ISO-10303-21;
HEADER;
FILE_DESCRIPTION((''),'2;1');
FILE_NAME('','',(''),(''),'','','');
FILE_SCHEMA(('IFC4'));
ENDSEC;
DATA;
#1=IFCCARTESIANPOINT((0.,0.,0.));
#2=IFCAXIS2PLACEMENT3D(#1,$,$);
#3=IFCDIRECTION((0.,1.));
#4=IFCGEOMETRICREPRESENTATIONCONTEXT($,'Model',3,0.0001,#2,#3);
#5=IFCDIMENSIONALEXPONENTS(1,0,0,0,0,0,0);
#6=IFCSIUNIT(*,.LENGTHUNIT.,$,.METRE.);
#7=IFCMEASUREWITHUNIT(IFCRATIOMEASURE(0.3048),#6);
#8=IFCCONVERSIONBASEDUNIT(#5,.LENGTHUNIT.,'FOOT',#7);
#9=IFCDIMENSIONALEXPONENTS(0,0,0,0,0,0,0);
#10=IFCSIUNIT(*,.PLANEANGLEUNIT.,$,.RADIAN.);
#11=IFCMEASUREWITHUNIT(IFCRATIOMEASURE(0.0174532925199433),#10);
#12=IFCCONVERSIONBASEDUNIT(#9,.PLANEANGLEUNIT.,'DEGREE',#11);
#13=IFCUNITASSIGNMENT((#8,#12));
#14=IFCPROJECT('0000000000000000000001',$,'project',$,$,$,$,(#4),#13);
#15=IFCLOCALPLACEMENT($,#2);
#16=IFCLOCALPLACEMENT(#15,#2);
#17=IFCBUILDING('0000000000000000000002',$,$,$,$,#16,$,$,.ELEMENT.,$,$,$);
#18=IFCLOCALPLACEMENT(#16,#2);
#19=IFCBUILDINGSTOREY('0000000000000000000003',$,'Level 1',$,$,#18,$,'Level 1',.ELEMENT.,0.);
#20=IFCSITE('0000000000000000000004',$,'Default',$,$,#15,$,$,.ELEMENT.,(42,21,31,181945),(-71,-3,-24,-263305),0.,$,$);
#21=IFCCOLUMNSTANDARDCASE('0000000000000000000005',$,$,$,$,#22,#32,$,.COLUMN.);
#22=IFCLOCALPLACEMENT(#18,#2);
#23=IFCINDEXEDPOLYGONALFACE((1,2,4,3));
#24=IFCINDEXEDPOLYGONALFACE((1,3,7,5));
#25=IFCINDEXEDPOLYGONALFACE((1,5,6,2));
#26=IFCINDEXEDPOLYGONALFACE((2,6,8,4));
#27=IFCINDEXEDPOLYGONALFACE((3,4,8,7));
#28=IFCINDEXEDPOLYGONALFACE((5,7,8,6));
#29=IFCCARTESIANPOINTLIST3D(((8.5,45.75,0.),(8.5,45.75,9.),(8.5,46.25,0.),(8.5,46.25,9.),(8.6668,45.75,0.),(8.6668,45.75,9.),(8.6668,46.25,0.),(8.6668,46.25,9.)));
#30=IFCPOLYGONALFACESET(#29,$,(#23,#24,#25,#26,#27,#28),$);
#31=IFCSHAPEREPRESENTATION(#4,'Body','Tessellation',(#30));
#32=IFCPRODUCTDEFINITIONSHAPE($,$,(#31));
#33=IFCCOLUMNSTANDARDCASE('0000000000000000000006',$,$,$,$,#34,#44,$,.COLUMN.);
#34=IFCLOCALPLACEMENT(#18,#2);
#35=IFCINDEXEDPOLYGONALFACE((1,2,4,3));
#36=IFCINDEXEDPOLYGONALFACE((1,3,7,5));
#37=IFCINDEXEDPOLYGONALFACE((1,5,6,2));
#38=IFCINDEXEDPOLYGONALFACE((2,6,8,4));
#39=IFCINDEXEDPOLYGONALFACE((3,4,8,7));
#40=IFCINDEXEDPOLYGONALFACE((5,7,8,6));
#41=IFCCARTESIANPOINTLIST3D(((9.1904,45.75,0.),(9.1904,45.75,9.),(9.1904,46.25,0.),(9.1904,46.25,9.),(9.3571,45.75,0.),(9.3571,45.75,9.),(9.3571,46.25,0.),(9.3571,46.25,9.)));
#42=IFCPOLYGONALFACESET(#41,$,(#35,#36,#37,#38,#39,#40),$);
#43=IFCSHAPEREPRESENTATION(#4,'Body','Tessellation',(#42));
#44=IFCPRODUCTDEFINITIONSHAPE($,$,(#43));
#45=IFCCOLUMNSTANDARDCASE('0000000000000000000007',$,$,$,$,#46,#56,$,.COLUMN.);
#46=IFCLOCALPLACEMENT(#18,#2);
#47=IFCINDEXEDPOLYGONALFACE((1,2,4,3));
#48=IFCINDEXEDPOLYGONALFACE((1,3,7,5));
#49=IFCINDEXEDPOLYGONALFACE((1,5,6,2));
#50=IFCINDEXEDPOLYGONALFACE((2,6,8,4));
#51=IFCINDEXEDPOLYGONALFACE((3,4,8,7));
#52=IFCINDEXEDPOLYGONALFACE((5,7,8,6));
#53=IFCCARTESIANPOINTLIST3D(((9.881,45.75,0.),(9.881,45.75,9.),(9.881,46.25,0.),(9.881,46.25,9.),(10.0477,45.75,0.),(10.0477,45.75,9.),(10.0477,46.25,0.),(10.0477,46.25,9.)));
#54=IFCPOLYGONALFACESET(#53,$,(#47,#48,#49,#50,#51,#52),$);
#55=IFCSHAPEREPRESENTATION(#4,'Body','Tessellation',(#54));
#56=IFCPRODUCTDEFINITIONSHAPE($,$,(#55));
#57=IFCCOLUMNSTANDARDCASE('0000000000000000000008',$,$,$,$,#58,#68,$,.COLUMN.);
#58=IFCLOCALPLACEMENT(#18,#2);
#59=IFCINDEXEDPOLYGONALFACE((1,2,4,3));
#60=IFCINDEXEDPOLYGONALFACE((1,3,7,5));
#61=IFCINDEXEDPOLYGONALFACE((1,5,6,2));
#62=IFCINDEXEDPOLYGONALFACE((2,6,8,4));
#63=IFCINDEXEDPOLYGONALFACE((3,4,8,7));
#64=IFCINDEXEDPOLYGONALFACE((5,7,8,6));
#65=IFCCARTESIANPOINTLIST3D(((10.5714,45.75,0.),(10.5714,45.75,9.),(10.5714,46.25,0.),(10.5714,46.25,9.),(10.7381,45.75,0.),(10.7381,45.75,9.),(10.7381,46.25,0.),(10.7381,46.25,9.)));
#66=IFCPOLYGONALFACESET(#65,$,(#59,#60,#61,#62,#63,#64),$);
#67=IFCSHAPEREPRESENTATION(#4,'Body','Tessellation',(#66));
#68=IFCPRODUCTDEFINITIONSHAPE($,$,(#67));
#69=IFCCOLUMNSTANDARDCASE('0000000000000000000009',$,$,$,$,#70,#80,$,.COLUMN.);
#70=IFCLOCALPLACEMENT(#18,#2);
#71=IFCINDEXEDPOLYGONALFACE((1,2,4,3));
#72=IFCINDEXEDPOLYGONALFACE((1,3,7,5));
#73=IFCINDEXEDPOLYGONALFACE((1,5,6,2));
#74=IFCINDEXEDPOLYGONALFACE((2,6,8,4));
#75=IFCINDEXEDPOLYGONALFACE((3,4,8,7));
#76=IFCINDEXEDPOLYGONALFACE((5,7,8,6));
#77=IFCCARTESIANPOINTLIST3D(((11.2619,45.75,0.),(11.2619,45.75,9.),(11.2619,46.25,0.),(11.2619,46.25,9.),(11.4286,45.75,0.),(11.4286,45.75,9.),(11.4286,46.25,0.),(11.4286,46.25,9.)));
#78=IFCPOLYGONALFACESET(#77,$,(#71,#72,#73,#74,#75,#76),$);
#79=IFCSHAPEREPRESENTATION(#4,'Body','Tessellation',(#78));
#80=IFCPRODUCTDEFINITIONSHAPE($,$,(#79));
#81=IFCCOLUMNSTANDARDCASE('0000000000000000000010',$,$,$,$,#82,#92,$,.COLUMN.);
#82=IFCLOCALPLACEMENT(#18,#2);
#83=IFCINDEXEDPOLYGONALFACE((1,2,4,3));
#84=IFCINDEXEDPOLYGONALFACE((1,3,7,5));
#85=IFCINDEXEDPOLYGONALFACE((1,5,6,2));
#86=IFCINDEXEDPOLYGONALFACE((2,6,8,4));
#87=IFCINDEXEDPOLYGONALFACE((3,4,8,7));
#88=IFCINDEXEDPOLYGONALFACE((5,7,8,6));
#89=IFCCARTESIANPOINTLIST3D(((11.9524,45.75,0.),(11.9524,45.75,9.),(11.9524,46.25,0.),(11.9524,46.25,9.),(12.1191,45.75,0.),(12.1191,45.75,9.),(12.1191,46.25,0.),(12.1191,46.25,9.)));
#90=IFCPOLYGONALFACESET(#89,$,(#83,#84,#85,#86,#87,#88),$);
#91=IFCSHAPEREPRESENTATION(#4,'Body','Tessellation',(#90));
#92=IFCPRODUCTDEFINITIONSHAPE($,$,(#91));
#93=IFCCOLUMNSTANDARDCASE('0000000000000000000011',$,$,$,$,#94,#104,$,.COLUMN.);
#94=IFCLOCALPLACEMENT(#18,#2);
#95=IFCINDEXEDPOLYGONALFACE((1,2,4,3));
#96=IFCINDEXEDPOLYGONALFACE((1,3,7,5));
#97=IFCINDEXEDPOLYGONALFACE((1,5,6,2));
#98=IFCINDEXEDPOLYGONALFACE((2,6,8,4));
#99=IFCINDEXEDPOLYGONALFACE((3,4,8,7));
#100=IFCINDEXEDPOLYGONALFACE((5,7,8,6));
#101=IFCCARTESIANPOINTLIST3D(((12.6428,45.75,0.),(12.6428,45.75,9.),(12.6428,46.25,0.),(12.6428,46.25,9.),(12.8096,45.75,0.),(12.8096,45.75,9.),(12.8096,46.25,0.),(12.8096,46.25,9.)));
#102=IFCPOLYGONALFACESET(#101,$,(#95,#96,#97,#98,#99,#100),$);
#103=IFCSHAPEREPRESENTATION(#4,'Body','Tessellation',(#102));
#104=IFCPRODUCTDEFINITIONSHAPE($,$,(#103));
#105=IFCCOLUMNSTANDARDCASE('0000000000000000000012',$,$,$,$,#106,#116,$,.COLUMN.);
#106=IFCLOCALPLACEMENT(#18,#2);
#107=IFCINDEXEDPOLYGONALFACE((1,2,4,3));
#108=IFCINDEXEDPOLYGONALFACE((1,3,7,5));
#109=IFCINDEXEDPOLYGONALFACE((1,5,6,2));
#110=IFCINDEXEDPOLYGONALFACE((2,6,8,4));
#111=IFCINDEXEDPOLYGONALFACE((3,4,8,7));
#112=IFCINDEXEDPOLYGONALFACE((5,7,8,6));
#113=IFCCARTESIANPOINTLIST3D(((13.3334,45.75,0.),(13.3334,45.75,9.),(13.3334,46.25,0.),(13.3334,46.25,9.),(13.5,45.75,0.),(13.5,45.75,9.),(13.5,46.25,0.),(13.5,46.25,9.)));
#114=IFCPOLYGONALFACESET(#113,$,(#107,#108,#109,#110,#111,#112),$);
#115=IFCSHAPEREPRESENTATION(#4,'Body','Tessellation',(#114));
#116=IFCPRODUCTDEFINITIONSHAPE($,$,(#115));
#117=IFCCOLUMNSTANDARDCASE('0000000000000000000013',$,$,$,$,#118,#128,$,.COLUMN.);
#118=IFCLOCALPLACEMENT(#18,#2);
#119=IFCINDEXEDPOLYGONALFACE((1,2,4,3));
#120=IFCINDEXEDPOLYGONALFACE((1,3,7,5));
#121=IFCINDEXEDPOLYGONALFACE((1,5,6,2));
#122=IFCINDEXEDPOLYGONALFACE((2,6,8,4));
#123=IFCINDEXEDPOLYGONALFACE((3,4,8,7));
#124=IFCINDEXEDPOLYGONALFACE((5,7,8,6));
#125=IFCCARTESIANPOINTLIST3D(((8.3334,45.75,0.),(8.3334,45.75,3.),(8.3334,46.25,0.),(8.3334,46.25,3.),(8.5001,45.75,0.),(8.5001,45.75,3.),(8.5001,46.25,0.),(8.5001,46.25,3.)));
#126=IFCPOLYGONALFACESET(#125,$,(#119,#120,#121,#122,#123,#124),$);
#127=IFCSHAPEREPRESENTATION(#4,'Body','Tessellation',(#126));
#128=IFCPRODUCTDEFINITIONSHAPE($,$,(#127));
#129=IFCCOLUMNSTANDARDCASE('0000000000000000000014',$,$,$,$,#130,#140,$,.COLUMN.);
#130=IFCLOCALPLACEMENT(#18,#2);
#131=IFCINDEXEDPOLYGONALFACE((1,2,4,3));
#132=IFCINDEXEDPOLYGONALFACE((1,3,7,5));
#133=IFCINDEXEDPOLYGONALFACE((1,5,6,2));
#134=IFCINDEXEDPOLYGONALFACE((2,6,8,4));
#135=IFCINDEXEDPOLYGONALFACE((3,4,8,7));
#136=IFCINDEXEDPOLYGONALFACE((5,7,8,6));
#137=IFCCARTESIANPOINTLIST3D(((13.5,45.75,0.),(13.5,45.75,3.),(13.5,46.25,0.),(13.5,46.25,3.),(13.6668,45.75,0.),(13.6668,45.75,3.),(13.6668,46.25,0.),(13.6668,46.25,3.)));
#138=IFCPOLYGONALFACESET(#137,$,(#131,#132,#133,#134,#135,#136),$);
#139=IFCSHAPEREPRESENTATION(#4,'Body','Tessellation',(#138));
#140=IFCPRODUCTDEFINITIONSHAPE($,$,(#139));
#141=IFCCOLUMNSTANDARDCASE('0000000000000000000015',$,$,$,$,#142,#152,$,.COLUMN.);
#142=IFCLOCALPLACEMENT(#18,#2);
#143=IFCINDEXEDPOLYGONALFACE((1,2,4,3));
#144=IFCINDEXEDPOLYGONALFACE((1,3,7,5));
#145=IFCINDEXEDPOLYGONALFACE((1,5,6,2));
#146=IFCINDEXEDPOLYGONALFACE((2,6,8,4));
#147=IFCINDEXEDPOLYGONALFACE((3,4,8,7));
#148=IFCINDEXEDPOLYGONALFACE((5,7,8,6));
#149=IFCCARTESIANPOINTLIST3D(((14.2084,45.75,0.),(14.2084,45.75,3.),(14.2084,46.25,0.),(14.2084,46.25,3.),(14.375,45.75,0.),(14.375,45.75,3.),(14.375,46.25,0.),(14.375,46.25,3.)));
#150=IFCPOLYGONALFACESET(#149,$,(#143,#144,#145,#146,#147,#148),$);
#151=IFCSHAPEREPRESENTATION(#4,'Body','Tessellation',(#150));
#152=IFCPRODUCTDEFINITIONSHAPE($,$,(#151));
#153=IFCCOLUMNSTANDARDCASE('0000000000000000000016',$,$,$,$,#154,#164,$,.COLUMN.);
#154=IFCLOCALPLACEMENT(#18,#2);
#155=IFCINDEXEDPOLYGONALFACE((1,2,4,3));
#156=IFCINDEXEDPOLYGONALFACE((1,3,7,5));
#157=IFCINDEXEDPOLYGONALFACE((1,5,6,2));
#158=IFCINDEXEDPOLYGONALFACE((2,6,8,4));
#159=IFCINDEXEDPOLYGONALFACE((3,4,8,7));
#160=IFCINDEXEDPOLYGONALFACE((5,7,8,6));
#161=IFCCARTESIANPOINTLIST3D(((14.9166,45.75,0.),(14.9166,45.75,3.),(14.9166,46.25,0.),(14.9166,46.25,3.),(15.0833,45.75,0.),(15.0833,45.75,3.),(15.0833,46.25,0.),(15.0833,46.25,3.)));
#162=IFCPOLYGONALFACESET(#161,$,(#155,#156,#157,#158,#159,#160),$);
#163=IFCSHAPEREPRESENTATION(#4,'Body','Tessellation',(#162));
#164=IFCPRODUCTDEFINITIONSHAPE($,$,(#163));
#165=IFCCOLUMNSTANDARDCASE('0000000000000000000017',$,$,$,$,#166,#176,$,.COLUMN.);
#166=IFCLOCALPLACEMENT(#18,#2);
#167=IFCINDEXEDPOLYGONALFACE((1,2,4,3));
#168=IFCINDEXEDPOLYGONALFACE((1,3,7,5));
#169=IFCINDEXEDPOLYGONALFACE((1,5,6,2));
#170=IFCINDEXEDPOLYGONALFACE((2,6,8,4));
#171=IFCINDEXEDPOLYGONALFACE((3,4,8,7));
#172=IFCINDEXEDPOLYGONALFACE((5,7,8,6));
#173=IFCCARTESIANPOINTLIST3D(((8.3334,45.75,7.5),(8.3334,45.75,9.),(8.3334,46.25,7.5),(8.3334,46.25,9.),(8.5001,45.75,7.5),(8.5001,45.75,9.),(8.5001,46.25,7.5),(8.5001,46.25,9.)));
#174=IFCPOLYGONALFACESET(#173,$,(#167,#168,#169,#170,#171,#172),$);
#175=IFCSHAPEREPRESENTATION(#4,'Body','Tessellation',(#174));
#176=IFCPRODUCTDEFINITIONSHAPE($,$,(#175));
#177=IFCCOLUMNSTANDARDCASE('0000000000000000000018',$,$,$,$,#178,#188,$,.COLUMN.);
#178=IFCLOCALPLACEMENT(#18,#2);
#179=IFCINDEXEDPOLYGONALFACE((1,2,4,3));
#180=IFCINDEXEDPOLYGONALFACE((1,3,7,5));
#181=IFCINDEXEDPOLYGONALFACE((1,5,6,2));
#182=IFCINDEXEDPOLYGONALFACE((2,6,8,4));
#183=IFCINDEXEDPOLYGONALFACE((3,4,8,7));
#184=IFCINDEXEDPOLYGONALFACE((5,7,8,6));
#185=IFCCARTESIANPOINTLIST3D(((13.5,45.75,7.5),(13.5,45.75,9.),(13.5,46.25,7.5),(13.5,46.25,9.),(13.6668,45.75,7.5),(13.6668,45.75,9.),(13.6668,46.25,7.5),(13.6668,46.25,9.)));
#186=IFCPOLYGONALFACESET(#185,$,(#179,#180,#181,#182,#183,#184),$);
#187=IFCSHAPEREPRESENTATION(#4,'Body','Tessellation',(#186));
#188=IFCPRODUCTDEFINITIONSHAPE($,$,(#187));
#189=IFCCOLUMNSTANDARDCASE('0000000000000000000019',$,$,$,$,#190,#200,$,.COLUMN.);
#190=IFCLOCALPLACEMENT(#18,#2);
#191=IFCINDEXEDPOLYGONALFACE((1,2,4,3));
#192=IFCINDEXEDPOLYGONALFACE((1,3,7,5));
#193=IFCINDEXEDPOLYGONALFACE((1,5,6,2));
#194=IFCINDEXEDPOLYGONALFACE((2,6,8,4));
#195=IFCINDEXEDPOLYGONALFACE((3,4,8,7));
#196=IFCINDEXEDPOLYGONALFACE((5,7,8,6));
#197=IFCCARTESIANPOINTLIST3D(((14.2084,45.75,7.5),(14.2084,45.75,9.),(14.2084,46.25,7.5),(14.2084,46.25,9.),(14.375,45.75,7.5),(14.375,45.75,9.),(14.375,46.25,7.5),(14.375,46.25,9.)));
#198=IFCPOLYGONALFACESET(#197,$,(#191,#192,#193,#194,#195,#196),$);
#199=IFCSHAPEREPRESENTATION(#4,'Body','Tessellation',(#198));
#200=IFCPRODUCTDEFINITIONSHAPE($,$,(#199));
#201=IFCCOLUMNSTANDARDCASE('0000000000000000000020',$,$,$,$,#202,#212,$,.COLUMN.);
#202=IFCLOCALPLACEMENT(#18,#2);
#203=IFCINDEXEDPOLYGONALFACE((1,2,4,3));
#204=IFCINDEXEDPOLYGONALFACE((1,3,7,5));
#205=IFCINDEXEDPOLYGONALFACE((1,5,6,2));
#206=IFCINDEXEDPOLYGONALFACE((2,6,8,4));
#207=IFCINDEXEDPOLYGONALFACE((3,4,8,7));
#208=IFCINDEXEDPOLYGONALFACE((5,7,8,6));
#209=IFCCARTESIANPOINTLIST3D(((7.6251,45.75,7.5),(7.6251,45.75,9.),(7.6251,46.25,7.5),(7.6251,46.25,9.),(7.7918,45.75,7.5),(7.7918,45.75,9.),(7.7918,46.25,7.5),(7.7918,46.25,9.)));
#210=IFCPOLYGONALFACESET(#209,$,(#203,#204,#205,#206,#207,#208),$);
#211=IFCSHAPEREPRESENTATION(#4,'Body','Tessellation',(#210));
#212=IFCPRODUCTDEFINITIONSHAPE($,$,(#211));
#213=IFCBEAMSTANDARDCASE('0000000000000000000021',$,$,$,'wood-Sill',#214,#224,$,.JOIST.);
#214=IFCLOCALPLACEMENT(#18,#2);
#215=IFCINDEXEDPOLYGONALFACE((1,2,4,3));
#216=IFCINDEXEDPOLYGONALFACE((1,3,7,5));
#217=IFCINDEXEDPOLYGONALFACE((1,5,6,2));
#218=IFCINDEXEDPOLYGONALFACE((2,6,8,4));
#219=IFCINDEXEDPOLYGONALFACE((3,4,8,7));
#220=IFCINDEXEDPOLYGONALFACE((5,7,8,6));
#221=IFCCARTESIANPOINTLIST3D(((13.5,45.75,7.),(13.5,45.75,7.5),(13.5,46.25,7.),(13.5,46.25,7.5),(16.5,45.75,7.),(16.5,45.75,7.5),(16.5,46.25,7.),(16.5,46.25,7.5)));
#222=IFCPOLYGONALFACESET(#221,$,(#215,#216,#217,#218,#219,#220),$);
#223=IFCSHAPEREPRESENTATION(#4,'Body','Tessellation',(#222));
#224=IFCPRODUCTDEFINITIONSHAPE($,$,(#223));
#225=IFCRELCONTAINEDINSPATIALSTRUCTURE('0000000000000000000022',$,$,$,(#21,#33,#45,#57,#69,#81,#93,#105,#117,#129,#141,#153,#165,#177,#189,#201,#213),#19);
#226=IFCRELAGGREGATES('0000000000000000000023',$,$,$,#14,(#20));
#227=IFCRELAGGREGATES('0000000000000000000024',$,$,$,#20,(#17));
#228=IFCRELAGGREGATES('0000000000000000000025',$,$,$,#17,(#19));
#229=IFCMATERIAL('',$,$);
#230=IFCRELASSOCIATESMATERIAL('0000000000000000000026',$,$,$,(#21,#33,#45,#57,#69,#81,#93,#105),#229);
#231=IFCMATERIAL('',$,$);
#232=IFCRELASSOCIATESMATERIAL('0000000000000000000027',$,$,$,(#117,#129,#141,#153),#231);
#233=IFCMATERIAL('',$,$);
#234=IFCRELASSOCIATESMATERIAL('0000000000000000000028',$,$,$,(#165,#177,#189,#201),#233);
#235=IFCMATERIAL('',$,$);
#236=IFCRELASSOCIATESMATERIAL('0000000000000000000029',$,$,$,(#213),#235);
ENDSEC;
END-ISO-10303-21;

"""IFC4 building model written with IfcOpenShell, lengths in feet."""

from ifc_helpers import new_model, entity, si_unit, converted_unit, direction, frame, origin, place, context, project, spatial, rectangle, extrude, material, element, save


model = new_model("IFC4")

# Units and contexts
model_context = context("Model", 3, precision=0.0001, world=origin(), true_north=direction((0.0, 1.0)))
ifc_project = project(units=[converted_unit("LENGTHUNIT", "FOOT", entity("IfcRatioMeasure", 0.3048), si_unit("LENGTHUNIT", "METRE"), dimensions=[1, 0, 0, 0, 0, 0, 0]), converted_unit("PLANEANGLEUNIT", "DEGREE", entity("IfcRatioMeasure", 0.0174532925199433), si_unit("PLANEANGLEUNIT", "RADIAN"), dimensions=[0, 0, 0, 0, 0, 0, 0])], contexts=[model_context])

# Site, building, storey
site_placement = place(None, origin())
site = spatial("IfcSite", under=ifc_project, at=site_placement, Name="Default", CompositionType="ELEMENT", RefLatitude=(42, 21, 31, 181945), RefLongitude=(-71, -3, -24, -263305), RefElevation=0.0)
building_placement = place(site_placement, origin())
building = spatial("IfcBuilding", under=site, at=building_placement, CompositionType="ELEMENT")
storey_placement = place(building_placement, origin())
storey = spatial("IfcBuildingStorey", under=building, at=storey_placement, Name="Level 1", LongName="Level 1", CompositionType="ELEMENT", Elevation=0.0)

# Columns
ifc_material_1 = material(Name="")
placement_1 = place(storey_placement, frame((-0.25, 46.0, 0.0)))
for number, where, z_axis, x_axis in (
    (1, (8.8334, 0.0, 0.0), (0.0, 0.0, 1.0), (1.0, 0.0, 0.0)),
    (2, (9.5238, 0.0, 0.0), (0.0, 0.0, 1.0), (1.0, 0.0, 0.0)),
    (3, (10.2143, 0.0, 0.0), (0.0, 0.0, 1.0), (1.0, 0.0, 0.0)),
    (4, (10.9048, 0.0, 0.0), (0.0, 0.0, 1.0), (1.0, 0.0, 0.0)),
    (5, (11.5953, 0.0, 0.0), (0.0, 0.0, 1.0), (1.0, 0.0, 0.0)),
    (6, (12.2857, 0.0, 0.0), (0.0, 0.0, 1.0), (1.0, 0.0, 0.0)),
    (7, (12.9762, 0.0, 0.0), (0.0, 0.0, 1.0), (1.0, 0.0, 0.0)),
    (8, (13.6667, 0.0, 0.0), (0.0, 0.0, 1.0), (1.0, 0.0, 0.0)),
):
    element("IfcColumnStandardCase", number, at=place(placement_1, frame(where, z_axis=z_axis, x_axis=x_axis)), inside=storey, material=ifc_material_1, PredefinedType="COLUMN", context=model_context, shape_type="SweptSolid", body=[
        extrude(rectangle(XDim=0.1667, YDim=0.5), origin(), (0.0, 0.0, 1.0), 9.0),
    ])
ifc_material_2 = material(Name="")
for number, where, z_axis, x_axis in (
    (9, (8.6667, 0.0, 0.0), (0.0, 0.0, 1.0), (1.0, 0.0, 0.0)),
    (10, (13.8334, 0.0, 0.0), (0.0, 0.0, 1.0), (1.0, 0.0, 0.0)),
    (11, (14.5417, 0.0, 0.0), (0.0, 0.0, 1.0), (1.0, 0.0, 0.0)),
    (12, (15.25, 0.0, 0.0), (0.0, 0.0, 1.0), (1.0, 0.0, 0.0)),
):
    element("IfcColumnStandardCase", number, at=place(placement_1, frame(where, z_axis=z_axis, x_axis=x_axis)), inside=storey, material=ifc_material_2, PredefinedType="COLUMN", context=model_context, shape_type="SweptSolid", body=[
        extrude(rectangle(XDim=0.1667, YDim=0.5), origin(), (0.0, 0.0, 1.0), 3.0),
    ])
ifc_material_3 = material(Name="")
for number, where, z_axis, x_axis in (
    (13, (8.6667, 0.0, 7.5), (0.0, 0.0, 1.0), (1.0, 0.0, 0.0)),
    (14, (13.8334, 0.0, 7.5), (0.0, 0.0, 1.0), (1.0, 0.0, 0.0)),
    (15, (14.5417, 0.0, 7.5), (0.0, 0.0, 1.0), (1.0, 0.0, 0.0)),
    (16, (7.9584, 0.0, 7.5), (0.0, 0.0, 1.0), (1.0, 0.0, 0.0)),
):
    element("IfcColumnStandardCase", number, at=place(placement_1, frame(where, z_axis=z_axis, x_axis=x_axis)), inside=storey, material=ifc_material_3, PredefinedType="COLUMN", context=model_context, shape_type="SweptSolid", body=[
        extrude(rectangle(XDim=0.1667, YDim=0.5), origin(), (0.0, 0.0, 1.0), 1.5),
    ])

# Beam
ifc_material_4 = material(Name="")
for number, where, z_axis, x_axis in (
    (17, (15.25, 0.0, 7.0), (0.0, 0.0, 1.0), (1.0, 0.0, 0.0)),
):
    element("IfcBeamStandardCase", number, at=place(placement_1, frame(where, z_axis=z_axis, x_axis=x_axis)), inside=storey, material=ifc_material_4, ObjectType="wood-Sill", PredefinedType="JOIST", context=model_context, shape_type="SweptSolid", body=[
        extrude(rectangle(XDim=3.0, YDim=0.5), origin(), (0.0, 0.0, 1.0), 0.5),
    ])

save(model, "model.ifc")
